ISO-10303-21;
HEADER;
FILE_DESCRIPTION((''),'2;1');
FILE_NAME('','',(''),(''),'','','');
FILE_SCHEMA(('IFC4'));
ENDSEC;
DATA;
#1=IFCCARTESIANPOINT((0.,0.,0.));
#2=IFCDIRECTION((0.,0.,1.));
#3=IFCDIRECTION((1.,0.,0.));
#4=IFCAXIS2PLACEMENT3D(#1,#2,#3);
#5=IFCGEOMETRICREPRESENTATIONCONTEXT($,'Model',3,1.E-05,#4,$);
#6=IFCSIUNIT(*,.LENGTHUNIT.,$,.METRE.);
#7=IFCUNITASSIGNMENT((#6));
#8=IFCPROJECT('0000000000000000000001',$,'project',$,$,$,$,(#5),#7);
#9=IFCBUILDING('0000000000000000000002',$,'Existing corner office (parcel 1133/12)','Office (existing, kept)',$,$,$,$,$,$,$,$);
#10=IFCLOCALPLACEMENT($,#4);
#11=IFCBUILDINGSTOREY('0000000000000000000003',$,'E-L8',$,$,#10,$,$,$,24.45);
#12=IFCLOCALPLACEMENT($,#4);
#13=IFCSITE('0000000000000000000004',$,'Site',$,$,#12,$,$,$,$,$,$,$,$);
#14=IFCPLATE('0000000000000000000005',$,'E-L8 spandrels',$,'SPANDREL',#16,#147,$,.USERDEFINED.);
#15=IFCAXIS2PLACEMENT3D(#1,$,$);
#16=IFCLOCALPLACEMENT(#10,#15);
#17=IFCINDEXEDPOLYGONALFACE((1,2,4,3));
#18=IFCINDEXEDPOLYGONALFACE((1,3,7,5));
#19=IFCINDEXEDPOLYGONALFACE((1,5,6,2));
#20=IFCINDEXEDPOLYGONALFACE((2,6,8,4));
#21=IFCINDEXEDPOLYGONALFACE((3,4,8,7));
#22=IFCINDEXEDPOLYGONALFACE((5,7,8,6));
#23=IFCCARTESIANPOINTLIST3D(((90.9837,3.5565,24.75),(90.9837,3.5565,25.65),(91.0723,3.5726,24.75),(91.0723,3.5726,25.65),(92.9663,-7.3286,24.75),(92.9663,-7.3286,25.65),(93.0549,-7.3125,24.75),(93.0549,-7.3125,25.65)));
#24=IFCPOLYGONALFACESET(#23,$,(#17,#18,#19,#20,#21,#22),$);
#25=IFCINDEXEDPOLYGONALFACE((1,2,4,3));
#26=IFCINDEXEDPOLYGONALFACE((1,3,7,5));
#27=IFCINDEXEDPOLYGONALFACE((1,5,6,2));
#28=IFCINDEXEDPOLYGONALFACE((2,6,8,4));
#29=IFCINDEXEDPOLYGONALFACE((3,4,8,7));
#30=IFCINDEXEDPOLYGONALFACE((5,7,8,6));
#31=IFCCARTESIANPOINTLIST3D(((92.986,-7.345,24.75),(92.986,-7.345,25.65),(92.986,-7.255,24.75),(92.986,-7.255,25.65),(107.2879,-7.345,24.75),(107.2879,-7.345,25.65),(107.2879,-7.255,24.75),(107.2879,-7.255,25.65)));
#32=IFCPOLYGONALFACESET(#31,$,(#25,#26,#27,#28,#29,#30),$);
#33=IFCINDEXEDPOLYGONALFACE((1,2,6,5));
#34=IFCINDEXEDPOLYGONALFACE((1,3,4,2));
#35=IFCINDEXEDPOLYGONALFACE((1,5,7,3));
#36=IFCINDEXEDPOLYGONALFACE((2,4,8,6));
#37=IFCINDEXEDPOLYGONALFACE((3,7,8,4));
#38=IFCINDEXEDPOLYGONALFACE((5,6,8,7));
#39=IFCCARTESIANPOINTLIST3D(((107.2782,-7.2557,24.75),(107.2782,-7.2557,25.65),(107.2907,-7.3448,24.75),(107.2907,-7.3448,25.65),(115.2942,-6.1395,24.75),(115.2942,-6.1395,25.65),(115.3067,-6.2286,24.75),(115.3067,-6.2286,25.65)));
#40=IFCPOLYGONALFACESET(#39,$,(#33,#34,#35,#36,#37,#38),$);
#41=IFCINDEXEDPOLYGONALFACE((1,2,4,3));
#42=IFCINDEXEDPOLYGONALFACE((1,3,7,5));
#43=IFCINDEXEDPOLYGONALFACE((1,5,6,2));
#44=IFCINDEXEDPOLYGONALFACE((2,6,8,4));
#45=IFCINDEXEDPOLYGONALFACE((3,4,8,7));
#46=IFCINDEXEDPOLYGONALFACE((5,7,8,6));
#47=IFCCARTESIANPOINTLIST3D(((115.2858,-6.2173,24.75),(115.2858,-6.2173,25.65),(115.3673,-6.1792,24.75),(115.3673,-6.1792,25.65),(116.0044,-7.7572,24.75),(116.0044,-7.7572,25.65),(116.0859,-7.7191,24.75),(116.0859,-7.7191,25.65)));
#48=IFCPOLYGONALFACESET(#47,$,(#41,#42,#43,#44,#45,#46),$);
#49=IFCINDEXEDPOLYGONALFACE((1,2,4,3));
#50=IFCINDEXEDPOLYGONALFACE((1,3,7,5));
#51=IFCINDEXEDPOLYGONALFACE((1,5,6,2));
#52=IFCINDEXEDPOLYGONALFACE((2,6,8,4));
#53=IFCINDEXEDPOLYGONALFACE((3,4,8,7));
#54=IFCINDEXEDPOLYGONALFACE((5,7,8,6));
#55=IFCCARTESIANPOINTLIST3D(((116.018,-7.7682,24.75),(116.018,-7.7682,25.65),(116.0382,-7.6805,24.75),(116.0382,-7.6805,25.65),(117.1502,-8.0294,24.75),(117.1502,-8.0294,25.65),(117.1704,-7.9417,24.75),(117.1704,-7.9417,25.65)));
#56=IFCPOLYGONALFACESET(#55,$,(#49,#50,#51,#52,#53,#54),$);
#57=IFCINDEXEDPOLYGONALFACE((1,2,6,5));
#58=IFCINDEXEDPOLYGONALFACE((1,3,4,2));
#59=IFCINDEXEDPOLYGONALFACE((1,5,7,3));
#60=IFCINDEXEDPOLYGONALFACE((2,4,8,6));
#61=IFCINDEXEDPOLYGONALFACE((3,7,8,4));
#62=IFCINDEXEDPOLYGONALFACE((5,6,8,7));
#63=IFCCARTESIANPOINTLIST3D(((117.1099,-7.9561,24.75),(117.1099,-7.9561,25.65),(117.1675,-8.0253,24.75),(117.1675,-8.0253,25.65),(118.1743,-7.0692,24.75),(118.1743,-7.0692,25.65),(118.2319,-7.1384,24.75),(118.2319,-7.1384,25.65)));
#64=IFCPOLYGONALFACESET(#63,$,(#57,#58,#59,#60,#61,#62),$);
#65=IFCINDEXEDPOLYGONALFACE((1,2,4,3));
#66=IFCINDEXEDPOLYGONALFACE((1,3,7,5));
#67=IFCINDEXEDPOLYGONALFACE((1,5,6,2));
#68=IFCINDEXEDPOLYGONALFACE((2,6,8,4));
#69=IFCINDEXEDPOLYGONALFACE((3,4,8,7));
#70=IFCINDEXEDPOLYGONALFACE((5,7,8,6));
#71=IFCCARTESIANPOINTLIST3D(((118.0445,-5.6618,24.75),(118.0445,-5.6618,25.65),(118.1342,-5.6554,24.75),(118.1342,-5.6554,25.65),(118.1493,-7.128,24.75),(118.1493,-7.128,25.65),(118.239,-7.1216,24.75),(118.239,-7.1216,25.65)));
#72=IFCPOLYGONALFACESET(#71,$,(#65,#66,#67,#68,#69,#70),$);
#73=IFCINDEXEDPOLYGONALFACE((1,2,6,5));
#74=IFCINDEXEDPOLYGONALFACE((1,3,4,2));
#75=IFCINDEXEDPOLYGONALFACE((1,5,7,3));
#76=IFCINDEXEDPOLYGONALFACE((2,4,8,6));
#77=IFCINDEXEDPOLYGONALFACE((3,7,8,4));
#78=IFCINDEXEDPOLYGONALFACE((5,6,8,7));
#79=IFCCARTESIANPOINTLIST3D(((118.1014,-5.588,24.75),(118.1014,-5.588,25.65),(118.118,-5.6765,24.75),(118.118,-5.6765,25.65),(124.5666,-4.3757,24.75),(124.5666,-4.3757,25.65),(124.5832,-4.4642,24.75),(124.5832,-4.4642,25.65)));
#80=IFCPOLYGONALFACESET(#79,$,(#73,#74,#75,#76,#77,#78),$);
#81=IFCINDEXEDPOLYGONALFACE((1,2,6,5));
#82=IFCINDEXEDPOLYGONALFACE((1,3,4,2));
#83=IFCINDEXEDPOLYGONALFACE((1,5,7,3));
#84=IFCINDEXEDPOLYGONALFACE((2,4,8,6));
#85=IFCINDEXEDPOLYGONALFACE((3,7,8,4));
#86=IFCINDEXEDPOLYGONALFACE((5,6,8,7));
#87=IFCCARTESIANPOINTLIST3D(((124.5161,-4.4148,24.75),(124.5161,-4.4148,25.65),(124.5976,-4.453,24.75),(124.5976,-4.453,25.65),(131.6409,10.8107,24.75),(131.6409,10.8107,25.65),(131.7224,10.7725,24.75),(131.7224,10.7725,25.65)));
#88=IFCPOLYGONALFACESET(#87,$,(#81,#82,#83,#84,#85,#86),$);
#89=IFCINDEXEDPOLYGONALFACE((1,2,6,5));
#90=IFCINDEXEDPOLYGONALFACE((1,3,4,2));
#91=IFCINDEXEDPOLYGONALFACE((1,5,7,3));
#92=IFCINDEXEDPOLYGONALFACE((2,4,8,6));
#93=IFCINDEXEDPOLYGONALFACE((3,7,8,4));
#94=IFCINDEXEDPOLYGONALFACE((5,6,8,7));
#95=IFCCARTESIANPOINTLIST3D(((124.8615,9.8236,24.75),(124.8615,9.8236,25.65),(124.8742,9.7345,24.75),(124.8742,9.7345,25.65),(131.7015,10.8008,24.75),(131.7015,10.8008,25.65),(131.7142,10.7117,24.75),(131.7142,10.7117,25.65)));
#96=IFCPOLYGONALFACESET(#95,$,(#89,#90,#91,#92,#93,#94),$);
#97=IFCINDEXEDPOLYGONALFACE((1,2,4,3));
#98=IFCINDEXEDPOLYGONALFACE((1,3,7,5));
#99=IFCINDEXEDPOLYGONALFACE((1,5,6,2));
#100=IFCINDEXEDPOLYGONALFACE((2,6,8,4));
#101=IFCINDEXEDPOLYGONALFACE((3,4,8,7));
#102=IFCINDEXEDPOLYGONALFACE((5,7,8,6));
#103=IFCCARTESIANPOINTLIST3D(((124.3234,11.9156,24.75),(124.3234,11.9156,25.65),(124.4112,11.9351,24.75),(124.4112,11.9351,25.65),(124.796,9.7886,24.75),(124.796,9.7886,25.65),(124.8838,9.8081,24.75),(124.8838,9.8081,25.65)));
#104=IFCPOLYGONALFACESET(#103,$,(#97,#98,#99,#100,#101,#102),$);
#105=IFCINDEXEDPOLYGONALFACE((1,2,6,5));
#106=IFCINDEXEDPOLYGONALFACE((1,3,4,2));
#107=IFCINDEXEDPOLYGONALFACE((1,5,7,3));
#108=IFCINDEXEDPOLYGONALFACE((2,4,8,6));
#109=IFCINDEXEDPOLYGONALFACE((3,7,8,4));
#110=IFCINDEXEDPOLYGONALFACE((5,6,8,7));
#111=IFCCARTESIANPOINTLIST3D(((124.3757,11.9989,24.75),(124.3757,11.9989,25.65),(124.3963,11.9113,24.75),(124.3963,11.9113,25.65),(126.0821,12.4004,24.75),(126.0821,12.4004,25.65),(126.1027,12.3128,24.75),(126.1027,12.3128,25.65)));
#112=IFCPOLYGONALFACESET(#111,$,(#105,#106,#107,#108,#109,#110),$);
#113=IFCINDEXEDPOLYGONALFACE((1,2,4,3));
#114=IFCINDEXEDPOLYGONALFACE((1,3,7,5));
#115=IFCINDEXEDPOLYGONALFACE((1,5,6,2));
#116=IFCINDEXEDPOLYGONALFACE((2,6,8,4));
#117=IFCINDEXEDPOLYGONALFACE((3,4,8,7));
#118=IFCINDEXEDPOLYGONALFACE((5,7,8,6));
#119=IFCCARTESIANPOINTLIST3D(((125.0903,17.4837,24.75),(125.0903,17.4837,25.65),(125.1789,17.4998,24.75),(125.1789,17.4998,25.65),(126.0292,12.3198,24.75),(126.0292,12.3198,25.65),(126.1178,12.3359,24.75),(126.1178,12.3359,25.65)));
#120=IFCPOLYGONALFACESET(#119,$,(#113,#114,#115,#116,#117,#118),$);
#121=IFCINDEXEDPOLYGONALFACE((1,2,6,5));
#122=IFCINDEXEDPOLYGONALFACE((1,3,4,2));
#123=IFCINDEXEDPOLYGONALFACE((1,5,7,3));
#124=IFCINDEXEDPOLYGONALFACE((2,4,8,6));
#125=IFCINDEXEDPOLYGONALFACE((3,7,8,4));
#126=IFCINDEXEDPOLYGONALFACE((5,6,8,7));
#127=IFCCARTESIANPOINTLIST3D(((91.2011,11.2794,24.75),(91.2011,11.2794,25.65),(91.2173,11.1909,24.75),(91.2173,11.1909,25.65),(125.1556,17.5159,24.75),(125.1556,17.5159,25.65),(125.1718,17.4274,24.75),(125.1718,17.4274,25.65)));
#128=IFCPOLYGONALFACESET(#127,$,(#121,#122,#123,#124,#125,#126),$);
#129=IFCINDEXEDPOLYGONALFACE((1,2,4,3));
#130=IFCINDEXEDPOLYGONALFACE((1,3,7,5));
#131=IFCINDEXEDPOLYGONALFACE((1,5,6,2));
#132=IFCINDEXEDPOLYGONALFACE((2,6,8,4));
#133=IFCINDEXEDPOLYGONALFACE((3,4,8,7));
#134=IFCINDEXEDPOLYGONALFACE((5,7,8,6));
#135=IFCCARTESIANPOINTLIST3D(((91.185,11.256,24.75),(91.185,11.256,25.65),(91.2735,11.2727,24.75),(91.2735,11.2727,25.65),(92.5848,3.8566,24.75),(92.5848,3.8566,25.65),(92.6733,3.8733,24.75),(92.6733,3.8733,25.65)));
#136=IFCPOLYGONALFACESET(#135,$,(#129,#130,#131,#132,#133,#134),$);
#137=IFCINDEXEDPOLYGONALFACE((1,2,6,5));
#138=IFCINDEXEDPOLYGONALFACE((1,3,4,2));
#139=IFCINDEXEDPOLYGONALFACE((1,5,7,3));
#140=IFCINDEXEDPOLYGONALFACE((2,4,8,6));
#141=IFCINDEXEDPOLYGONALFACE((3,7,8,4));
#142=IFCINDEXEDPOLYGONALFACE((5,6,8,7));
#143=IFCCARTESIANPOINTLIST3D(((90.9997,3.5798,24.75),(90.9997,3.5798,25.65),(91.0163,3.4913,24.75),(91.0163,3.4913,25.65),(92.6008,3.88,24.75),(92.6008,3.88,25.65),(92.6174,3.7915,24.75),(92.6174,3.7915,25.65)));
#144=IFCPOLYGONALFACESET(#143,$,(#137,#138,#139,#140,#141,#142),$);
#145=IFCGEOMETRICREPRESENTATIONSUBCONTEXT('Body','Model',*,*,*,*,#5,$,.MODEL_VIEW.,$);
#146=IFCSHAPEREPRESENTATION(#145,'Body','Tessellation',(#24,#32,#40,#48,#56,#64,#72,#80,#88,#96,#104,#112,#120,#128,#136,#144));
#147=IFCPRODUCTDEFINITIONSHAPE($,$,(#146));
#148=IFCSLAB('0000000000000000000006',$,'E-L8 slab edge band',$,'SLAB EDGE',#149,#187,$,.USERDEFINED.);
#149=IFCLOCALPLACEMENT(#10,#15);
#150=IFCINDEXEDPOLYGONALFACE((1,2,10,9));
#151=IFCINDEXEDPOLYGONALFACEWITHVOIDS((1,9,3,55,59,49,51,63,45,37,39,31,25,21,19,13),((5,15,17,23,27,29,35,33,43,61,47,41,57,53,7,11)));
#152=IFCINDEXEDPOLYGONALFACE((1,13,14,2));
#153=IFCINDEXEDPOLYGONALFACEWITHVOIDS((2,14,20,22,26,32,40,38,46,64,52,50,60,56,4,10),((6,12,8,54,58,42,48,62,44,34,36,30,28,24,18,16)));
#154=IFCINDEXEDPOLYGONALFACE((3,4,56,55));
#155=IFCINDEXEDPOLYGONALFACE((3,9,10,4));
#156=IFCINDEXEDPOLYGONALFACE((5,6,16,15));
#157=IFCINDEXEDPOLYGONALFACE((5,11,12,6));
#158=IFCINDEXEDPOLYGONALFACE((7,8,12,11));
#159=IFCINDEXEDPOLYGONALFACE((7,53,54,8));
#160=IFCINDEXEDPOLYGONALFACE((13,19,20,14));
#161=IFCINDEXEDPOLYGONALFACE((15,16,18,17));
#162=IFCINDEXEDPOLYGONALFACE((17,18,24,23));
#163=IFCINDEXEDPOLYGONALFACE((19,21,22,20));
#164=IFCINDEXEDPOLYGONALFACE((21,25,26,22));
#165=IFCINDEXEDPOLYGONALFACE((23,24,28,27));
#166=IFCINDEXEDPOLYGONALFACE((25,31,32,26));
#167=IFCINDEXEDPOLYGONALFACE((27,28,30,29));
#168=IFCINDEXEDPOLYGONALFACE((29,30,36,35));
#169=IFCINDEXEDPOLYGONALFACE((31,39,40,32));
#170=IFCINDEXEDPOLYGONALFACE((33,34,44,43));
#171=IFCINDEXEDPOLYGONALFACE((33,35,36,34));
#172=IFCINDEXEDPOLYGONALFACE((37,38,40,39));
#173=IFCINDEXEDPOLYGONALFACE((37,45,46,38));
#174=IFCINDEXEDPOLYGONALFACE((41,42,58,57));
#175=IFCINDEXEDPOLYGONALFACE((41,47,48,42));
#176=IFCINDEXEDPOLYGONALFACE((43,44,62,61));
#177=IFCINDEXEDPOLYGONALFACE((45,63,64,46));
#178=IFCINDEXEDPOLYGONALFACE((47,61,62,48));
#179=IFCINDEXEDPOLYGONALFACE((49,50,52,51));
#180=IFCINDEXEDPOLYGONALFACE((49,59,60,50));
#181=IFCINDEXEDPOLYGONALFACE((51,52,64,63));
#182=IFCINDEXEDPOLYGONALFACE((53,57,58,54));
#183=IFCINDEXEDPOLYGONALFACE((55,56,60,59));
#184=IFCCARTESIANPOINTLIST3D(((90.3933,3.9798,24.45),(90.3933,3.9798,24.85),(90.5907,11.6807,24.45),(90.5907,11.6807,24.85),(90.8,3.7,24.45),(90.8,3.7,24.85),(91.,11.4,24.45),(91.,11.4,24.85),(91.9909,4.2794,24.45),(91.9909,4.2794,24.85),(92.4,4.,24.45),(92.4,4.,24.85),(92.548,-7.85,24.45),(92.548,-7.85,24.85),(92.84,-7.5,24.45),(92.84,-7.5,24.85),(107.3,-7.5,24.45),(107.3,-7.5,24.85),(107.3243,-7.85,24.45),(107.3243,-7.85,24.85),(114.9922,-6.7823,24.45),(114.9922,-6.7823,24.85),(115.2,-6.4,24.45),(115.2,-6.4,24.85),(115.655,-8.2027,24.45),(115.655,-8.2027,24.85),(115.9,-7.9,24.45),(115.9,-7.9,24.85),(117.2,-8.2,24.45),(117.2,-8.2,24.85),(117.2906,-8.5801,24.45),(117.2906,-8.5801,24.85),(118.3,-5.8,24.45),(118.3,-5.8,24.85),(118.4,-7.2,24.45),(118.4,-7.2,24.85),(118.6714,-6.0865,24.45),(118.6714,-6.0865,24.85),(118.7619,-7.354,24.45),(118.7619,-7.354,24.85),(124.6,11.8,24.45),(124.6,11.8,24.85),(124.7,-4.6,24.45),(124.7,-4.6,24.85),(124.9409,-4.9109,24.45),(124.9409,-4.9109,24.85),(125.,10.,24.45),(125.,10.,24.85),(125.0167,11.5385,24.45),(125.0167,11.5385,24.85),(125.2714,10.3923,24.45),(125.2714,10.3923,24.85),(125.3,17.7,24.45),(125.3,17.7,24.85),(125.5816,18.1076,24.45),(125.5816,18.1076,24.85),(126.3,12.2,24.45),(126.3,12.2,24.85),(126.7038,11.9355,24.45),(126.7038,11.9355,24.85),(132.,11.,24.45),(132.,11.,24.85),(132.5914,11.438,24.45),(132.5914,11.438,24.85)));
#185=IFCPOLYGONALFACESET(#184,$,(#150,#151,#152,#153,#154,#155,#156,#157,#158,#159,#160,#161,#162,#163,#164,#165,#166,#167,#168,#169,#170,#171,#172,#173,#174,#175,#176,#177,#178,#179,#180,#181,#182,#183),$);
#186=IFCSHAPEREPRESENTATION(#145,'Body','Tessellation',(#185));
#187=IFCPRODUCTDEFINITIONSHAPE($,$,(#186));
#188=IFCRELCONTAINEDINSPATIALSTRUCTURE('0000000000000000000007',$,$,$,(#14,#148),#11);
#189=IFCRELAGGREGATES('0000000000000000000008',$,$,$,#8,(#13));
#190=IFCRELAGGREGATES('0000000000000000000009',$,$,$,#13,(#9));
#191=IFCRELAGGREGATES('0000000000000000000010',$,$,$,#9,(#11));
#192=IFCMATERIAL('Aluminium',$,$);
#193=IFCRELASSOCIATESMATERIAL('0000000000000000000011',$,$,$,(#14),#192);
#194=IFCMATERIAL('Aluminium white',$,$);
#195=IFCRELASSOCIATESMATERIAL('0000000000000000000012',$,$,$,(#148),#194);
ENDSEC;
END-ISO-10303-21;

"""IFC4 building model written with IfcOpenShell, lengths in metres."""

from ifc_helpers import new_model, si_unit, frame, origin_with_axes, place, context, subcontext, project, spatial, polyline, outline, extrude, material, element, save


model = new_model("IFC4")

# Units and contexts
model_context = context("Model", 3, precision=1e-05, world=origin_with_axes())
body_context = subcontext(model_context, "Body", "Model", "MODEL_VIEW")
ifc_project = project(units=[si_unit("LENGTHUNIT", "METRE")], contexts=[model_context])

# Site, building, storey
site_placement = place(None, origin_with_axes())
site = spatial("IfcSite", under=ifc_project, at=site_placement, Name="Site")
building = spatial("IfcBuilding", under=site, Name="Existing corner office (parcel 1133/12)", Description="Office (existing, kept)")
storey_placement = place(None, origin_with_axes())
storey = spatial("IfcBuildingStorey", under=building, at=storey_placement, Name="E-L8", Elevation=24.45)

# Shared definitions
ifc_material_1 = material(Name="Aluminium")
ifc_material_2 = material(Name="Aluminium white")

# Plate
plate_placement = place(storey_placement, origin_with_axes())
element("IfcPlate", 1, at=plate_placement, inside=storey, material=ifc_material_1, Name="E-L8 spandrels", ObjectType="SPANDREL", PredefinedType="USERDEFINED", context=body_context, shape_type="SweptSolid", body=[
    extrude(outline(polyline([(90.9837, 3.5565), (92.9663, -7.3286), (93.0549, -7.3125), (91.0723, 3.5726), (90.9837, 3.5565)])), frame((0.0, 0.0, 24.75), z_axis=(0.0, 0.0, 1.0), x_axis=(1.0, 0.0, 0.0)), (0.0, 0.0, 1.0), 0.9),
    extrude(outline(polyline([(92.986, -7.345), (107.2879, -7.345), (107.2879, -7.255), (92.986, -7.255), (92.986, -7.345)])), frame((0.0, 0.0, 24.75), z_axis=(0.0, 0.0, 1.0), x_axis=(1.0, 0.0, 0.0)), (0.0, 0.0, 1.0), 0.9),
    extrude(outline(polyline([(107.2907, -7.3448), (115.3067, -6.2286), (115.2942, -6.1395), (107.2782, -7.2557), (107.2907, -7.3448)])), frame((0.0, 0.0, 24.75), z_axis=(0.0, 0.0, 1.0), x_axis=(1.0, 0.0, 0.0)), (0.0, 0.0, 1.0), 0.9),
    extrude(outline(polyline([(115.2858, -6.2173), (116.0044, -7.7572), (116.0859, -7.7191), (115.3673, -6.1792), (115.2858, -6.2173)])), frame((0.0, 0.0, 24.75), z_axis=(0.0, 0.0, 1.0), x_axis=(1.0, 0.0, 0.0)), (0.0, 0.0, 1.0), 0.9),
    extrude(outline(polyline([(116.018, -7.7682), (117.1502, -8.0294), (117.1704, -7.9417), (116.0382, -7.6805), (116.018, -7.7682)])), frame((0.0, 0.0, 24.75), z_axis=(0.0, 0.0, 1.0), x_axis=(1.0, 0.0, 0.0)), (0.0, 0.0, 1.0), 0.9),
    extrude(outline(polyline([(117.1675, -8.0253), (118.2319, -7.1384), (118.1743, -7.0692), (117.1099, -7.9561), (117.1675, -8.0253)])), frame((0.0, 0.0, 24.75), z_axis=(0.0, 0.0, 1.0), x_axis=(1.0, 0.0, 0.0)), (0.0, 0.0, 1.0), 0.9),
    extrude(outline(polyline([(118.239, -7.1216), (118.1342, -5.6554), (118.0445, -5.6618), (118.1493, -7.128), (118.239, -7.1216)])), frame((0.0, 0.0, 24.75), z_axis=(0.0, 0.0, 1.0), x_axis=(1.0, 0.0, 0.0)), (0.0, 0.0, 1.0), 0.9),
    extrude(outline(polyline([(118.118, -5.6765), (124.5832, -4.4642), (124.5666, -4.3757), (118.1014, -5.588), (118.118, -5.6765)])), frame((0.0, 0.0, 24.75), z_axis=(0.0, 0.0, 1.0), x_axis=(1.0, 0.0, 0.0)), (0.0, 0.0, 1.0), 0.9),
    extrude(outline(polyline([(124.5976, -4.453), (131.7224, 10.7725), (131.6409, 10.8107), (124.5161, -4.4148), (124.5976, -4.453)])), frame((0.0, 0.0, 24.75), z_axis=(0.0, 0.0, 1.0), x_axis=(1.0, 0.0, 0.0)), (0.0, 0.0, 1.0), 0.9),
    extrude(outline(polyline([(131.7015, 10.8008), (124.8615, 9.8236), (124.8742, 9.7345), (131.7142, 10.7117), (131.7015, 10.8008)])), frame((0.0, 0.0, 24.75), z_axis=(0.0, 0.0, 1.0), x_axis=(1.0, 0.0, 0.0)), (0.0, 0.0, 1.0), 0.9),
    extrude(outline(polyline([(124.8838, 9.8081), (124.4112, 11.9351), (124.3234, 11.9156), (124.796, 9.7886), (124.8838, 9.8081)])), frame((0.0, 0.0, 24.75), z_axis=(0.0, 0.0, 1.0), x_axis=(1.0, 0.0, 0.0)), (0.0, 0.0, 1.0), 0.9),
    extrude(outline(polyline([(124.3963, 11.9113), (126.1027, 12.3128), (126.0821, 12.4004), (124.3757, 11.9989), (124.3963, 11.9113)])), frame((0.0, 0.0, 24.75), z_axis=(0.0, 0.0, 1.0), x_axis=(1.0, 0.0, 0.0)), (0.0, 0.0, 1.0), 0.9),
    extrude(outline(polyline([(126.1178, 12.3359), (125.1789, 17.4998), (125.0903, 17.4837), (126.0292, 12.3198), (126.1178, 12.3359)])), frame((0.0, 0.0, 24.75), z_axis=(0.0, 0.0, 1.0), x_axis=(1.0, 0.0, 0.0)), (0.0, 0.0, 1.0), 0.9),
    extrude(outline(polyline([(125.1556, 17.5159), (91.2011, 11.2794), (91.2173, 11.1909), (125.1718, 17.4274), (125.1556, 17.5159)])), frame((0.0, 0.0, 24.75), z_axis=(0.0, 0.0, 1.0), x_axis=(1.0, 0.0, 0.0)), (0.0, 0.0, 1.0), 0.9),
    extrude(outline(polyline([(91.185, 11.256), (92.5848, 3.8566), (92.6733, 3.8733), (91.2735, 11.2727), (91.185, 11.256)])), frame((0.0, 0.0, 24.75), z_axis=(0.0, 0.0, 1.0), x_axis=(1.0, 0.0, 0.0)), (0.0, 0.0, 1.0), 0.9),
    extrude(outline(polyline([(92.6008, 3.88), (90.9997, 3.5798), (91.0163, 3.4913), (92.6174, 3.7915), (92.6008, 3.88)])), frame((0.0, 0.0, 24.75), z_axis=(0.0, 0.0, 1.0), x_axis=(1.0, 0.0, 0.0)), (0.0, 0.0, 1.0), 0.9),
])

# Slab
slab_1_placement = place(storey_placement, origin_with_axes())
element("IfcSlab", 2, at=slab_1_placement, inside=storey, material=ifc_material_2, Name="E-L8 slab edge band", ObjectType="SLAB EDGE", PredefinedType="USERDEFINED", context=body_context, shape_type="SweptSolid", body=[
    extrude(outline(polyline([(90.3933, 3.9798), (92.548, -7.85), (107.3243, -7.85), (114.9922, -6.7823), (115.655, -8.2027), (117.2906, -8.5801), (118.7619, -7.354), (118.6714, -6.0865), (124.9409, -4.9109), (132.5914, 11.438), (125.2714, 10.3923), (125.0167, 11.5385), (126.7038, 11.9355), (125.5816, 18.1076), (90.5907, 11.6807), (91.9909, 4.2794), (90.3933, 3.9798)]), holes=[polyline([(90.8, 3.7), (92.84, -7.5), (107.3, -7.5), (115.2, -6.4), (115.9, -7.9), (117.2, -8.2), (118.4, -7.2), (118.3, -5.8), (124.7, -4.6), (132.0, 11.0), (125.0, 10.0), (124.6, 11.8), (126.3, 12.2), (125.3, 17.7), (91.0, 11.4), (92.4, 4.0), (90.8, 3.7)])]), frame((0.0, 0.0, 24.45), z_axis=(0.0, 0.0, 1.0), x_axis=(1.0, 0.0, 0.0)), (0.0, 0.0, 1.0), 0.4),
])

save(model, "model.ifc")
